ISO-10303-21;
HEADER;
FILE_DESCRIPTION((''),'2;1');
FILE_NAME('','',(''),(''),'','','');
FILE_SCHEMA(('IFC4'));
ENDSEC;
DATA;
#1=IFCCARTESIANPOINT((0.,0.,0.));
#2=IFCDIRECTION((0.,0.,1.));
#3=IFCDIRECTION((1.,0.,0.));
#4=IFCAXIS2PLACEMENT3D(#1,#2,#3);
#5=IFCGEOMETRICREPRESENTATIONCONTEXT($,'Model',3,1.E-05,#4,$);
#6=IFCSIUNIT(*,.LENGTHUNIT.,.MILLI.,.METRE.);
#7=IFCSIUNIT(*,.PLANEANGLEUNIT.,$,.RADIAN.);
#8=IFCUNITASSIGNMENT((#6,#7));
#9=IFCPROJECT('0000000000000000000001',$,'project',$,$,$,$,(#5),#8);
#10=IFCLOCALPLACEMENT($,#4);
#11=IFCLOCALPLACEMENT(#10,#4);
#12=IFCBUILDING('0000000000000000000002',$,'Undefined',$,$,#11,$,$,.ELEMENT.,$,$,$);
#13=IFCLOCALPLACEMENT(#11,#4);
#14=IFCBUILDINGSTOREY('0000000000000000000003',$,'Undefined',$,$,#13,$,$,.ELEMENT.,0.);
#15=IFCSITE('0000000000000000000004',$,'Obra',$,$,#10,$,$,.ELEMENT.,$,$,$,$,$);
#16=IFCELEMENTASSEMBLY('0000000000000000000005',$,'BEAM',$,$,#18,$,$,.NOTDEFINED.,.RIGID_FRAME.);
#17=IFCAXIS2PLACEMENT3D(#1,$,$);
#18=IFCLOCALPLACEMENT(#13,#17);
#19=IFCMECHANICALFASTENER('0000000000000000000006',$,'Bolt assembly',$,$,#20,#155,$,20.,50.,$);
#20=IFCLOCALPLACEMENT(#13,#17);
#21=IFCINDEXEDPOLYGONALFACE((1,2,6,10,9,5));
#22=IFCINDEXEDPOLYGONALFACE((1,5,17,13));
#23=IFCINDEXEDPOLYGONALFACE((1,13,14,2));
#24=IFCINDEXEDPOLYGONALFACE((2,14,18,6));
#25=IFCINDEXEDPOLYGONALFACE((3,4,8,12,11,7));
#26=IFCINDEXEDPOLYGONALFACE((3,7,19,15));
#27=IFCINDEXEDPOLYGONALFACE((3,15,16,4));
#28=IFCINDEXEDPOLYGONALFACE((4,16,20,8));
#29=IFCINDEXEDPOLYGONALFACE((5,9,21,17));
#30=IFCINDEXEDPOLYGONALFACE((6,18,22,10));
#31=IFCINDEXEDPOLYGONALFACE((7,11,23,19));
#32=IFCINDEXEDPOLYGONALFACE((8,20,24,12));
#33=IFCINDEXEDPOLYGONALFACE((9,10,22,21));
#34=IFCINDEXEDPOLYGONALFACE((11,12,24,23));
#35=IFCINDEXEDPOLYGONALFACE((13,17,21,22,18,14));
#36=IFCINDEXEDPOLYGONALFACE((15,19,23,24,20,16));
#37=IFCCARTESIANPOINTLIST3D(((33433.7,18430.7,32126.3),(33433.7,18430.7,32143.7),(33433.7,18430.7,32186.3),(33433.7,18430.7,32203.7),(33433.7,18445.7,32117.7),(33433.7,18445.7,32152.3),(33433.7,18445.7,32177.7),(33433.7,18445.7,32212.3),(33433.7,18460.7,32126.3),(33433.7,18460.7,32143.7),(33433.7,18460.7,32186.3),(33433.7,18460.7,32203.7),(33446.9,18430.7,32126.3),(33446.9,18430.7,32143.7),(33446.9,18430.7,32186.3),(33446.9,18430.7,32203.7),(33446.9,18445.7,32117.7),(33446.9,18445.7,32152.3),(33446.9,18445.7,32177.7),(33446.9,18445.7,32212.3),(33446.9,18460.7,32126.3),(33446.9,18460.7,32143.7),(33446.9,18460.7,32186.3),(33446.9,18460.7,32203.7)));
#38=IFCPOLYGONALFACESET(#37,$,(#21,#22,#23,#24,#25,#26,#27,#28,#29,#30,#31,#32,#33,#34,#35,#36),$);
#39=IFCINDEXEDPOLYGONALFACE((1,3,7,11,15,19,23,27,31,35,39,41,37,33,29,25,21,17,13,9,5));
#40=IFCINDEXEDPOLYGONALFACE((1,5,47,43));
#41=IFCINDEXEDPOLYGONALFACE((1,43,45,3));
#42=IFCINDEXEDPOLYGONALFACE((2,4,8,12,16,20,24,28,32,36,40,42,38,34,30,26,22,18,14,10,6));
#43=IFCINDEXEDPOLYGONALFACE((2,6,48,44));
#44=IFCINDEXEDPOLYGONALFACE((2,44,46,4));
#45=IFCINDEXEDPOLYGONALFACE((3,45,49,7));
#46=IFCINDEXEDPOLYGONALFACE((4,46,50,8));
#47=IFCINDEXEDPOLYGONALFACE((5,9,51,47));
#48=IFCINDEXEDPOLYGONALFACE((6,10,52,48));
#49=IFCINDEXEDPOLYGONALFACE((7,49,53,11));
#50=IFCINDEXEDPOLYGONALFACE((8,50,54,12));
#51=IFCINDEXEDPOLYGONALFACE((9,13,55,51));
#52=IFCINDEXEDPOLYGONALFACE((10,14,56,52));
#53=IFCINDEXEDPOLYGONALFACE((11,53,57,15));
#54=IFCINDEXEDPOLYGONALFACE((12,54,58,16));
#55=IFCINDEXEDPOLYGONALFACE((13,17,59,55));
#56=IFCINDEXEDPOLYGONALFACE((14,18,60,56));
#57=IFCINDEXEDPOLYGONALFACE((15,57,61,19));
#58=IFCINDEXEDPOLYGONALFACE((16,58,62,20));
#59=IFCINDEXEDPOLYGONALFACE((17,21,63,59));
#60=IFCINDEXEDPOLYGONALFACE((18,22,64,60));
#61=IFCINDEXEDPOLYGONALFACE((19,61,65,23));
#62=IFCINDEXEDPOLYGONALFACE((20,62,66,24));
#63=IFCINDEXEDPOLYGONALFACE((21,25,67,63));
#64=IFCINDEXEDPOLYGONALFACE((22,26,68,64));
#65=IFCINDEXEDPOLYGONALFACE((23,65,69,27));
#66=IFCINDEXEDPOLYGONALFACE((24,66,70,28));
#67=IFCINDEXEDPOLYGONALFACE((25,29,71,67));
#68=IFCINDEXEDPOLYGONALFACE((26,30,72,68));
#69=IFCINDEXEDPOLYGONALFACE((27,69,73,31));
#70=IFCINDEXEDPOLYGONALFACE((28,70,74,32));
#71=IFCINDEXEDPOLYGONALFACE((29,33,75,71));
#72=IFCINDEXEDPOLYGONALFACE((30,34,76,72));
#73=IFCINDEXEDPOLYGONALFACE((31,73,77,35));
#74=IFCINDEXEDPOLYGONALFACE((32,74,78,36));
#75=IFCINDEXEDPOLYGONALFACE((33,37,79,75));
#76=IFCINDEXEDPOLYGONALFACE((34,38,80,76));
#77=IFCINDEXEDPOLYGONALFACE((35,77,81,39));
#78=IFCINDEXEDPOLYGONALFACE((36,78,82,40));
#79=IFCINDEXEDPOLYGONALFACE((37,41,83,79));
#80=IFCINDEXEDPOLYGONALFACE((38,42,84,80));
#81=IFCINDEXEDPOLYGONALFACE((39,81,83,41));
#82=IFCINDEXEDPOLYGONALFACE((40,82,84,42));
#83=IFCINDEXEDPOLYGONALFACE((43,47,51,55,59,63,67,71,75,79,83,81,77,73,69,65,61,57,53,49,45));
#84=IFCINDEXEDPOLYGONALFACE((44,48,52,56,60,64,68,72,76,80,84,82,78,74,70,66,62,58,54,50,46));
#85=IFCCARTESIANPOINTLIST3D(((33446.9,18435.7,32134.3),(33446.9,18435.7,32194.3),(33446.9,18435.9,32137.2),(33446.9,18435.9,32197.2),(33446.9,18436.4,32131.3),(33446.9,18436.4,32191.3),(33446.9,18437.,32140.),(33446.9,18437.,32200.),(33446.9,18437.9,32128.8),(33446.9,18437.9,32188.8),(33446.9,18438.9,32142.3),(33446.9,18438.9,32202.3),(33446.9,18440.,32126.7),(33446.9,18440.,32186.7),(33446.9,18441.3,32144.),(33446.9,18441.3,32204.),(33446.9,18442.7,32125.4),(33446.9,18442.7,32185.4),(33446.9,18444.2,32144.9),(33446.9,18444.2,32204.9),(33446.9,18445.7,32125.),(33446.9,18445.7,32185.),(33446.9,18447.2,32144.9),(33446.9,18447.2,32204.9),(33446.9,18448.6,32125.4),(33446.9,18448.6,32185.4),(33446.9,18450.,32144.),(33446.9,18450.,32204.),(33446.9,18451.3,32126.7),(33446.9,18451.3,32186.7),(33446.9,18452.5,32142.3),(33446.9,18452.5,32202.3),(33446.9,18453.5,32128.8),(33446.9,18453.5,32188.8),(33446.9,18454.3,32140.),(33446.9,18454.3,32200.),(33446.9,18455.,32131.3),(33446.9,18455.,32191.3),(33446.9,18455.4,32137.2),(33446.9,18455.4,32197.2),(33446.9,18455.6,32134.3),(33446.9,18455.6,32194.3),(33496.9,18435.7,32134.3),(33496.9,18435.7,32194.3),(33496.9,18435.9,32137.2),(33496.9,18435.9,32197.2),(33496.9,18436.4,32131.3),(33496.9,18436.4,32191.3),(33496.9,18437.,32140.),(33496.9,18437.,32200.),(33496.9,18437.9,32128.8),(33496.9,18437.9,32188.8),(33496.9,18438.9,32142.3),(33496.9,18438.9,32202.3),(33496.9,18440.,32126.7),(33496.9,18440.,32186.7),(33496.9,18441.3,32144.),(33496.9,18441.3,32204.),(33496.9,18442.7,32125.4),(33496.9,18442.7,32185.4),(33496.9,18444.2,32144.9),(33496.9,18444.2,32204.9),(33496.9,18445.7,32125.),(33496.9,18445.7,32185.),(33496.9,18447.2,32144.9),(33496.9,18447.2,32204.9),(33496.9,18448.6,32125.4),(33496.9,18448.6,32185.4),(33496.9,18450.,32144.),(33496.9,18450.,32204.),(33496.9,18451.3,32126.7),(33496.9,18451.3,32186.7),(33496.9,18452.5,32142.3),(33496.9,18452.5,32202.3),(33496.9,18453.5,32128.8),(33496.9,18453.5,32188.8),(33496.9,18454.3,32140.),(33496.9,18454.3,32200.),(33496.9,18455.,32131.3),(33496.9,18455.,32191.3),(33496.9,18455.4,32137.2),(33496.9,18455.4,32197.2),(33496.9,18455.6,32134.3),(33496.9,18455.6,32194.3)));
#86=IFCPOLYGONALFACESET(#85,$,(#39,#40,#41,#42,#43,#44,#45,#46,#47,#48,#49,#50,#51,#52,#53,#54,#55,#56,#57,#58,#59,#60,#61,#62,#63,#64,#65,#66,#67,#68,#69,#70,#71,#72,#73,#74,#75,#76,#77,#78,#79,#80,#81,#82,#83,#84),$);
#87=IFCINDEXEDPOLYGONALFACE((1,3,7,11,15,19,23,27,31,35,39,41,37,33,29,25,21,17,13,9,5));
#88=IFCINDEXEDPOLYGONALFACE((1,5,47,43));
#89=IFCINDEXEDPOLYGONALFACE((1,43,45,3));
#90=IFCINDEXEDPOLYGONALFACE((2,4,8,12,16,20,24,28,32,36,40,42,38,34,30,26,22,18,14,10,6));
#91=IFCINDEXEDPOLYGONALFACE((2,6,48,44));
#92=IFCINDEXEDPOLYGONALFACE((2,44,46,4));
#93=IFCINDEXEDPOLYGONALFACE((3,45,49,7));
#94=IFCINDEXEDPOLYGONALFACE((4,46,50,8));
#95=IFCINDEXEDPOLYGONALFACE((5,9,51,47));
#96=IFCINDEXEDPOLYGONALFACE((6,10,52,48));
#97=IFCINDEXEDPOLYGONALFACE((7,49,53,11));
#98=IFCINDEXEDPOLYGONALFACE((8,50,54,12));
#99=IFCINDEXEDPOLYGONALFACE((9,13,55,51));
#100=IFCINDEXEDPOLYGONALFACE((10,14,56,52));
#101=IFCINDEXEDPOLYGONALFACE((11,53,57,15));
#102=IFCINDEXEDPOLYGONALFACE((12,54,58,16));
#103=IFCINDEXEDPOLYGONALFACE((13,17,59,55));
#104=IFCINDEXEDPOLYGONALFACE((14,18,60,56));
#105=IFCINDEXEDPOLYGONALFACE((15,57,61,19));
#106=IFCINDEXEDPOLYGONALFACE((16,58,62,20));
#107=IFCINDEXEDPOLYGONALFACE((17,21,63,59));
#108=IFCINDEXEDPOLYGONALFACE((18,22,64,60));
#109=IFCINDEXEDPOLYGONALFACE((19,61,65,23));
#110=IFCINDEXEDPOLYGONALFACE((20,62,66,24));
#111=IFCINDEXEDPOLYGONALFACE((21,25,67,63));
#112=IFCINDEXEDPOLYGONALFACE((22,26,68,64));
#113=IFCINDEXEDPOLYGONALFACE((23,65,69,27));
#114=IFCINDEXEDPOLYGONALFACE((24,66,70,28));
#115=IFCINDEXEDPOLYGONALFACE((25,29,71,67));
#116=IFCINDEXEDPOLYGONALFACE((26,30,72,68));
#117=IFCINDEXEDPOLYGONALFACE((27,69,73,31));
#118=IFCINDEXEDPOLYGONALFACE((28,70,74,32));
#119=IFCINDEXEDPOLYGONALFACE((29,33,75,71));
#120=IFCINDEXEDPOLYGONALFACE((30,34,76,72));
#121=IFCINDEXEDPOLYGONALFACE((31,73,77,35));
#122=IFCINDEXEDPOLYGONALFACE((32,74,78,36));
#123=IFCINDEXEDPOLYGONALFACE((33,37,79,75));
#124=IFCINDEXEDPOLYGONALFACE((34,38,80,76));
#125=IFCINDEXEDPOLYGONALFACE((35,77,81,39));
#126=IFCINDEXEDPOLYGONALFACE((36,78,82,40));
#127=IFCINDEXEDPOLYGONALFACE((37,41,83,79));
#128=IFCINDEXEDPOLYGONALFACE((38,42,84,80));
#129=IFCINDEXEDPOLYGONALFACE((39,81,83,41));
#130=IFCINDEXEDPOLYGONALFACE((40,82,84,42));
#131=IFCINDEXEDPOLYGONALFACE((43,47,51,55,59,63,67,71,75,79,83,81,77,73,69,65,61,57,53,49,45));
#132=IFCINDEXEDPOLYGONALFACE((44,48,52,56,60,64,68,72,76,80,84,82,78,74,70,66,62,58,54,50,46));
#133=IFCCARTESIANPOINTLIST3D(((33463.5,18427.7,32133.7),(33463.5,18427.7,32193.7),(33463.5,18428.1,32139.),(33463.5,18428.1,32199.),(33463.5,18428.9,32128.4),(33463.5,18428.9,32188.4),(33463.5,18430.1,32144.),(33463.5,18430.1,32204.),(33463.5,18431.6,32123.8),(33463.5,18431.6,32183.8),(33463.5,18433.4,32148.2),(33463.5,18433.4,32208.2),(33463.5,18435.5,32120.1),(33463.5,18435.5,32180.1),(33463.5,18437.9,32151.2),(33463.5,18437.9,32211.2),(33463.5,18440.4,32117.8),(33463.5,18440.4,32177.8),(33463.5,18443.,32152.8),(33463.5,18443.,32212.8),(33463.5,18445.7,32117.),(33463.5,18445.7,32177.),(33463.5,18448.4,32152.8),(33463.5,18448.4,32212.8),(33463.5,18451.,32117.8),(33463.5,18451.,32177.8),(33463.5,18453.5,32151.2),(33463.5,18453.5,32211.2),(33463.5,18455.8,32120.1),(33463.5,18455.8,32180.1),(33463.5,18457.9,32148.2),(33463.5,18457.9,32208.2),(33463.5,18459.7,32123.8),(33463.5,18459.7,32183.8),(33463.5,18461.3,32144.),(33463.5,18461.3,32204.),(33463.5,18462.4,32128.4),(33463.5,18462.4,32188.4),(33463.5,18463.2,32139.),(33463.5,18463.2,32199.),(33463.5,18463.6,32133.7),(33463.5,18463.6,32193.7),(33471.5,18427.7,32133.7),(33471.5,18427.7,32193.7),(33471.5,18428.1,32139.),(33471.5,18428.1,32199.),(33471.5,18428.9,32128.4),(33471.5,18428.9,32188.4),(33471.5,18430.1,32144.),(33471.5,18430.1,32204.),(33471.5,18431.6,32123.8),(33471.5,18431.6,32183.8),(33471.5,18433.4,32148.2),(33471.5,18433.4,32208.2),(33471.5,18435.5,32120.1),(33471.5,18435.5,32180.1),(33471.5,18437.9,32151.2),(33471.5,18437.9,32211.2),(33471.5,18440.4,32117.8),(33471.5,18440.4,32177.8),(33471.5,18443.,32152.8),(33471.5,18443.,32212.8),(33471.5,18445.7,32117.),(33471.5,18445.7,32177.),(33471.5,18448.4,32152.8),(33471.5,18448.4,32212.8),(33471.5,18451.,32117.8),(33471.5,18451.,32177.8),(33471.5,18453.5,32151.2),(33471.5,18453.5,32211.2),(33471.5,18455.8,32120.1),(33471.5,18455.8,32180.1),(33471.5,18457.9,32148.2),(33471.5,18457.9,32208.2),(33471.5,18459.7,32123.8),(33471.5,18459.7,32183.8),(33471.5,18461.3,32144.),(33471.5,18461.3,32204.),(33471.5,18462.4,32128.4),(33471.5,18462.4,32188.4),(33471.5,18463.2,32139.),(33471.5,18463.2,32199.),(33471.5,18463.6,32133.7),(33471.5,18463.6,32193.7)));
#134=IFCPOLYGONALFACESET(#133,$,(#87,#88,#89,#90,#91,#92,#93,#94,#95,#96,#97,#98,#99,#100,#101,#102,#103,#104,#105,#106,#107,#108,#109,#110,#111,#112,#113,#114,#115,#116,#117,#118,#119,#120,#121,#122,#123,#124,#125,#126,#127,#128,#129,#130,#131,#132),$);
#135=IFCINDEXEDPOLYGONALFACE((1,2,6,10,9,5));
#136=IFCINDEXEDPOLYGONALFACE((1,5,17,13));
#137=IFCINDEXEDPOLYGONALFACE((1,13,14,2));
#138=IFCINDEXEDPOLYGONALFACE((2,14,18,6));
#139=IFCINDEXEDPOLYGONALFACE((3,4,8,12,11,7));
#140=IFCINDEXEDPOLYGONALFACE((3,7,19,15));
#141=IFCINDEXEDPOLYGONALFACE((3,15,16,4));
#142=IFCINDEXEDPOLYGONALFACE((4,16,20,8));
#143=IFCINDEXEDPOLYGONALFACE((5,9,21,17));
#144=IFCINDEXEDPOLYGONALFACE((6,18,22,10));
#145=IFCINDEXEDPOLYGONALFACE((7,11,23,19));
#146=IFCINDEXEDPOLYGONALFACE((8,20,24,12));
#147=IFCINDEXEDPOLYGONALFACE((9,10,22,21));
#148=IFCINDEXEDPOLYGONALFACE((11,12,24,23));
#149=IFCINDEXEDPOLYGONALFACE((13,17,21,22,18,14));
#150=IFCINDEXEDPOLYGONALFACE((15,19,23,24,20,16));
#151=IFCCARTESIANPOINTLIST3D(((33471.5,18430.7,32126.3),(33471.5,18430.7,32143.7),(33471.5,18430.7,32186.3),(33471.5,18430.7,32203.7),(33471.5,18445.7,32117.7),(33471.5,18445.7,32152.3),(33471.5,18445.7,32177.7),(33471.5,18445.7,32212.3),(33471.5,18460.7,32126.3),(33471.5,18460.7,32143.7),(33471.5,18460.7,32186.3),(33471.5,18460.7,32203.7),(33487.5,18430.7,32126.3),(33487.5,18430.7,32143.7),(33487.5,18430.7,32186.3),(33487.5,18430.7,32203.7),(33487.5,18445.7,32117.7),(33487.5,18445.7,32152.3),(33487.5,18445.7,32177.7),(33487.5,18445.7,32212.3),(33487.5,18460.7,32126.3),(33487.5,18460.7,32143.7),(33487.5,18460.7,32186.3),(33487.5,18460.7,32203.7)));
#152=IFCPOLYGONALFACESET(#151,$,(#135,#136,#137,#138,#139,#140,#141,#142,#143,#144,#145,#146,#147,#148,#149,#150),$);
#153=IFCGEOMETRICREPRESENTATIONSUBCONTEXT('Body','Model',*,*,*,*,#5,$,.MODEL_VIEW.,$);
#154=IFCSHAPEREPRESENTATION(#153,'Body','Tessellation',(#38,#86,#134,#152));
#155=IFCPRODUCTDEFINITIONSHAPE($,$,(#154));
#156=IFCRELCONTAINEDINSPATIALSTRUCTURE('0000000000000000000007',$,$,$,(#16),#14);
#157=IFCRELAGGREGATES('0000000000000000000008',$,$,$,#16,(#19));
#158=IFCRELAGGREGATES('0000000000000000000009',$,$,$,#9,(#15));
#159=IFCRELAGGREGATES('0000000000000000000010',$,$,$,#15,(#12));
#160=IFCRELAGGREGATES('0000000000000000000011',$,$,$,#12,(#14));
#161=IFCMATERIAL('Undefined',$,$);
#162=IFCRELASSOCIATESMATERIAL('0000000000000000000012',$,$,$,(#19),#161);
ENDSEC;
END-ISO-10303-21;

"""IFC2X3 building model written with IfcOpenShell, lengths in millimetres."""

from ifc_helpers import new_model, si_unit, frame, origin_with_axes, origin_2d_with_axis, place, context, subcontext, project, spatial, polyline, circle, outline, extrude, source, transform, mapped, material, element, aggregate, save


model = new_model("IFC2X3")

# Units and contexts
model_context = context("Model", 3, precision=1e-05, world=origin_with_axes())
body_context = subcontext(model_context, "Body", "Model", "MODEL_VIEW")
ifc_project = project(units=[si_unit("LENGTHUNIT", "METRE", prefix="MILLI"), si_unit("PLANEANGLEUNIT", "RADIAN")], contexts=[model_context])

# Site, building, storey
site_placement = place(None, origin_with_axes())
site = spatial("IfcSite", under=ifc_project, at=site_placement, Name="Obra", CompositionType="ELEMENT")
building_placement = place(site_placement, origin_with_axes())
building = spatial("IfcBuilding", under=site, at=building_placement, Name="Undefined", CompositionType="ELEMENT")
storey_placement = place(building_placement, origin_with_axes())
storey = spatial("IfcBuildingStorey", under=building, at=storey_placement, Name="Undefined", CompositionType="ELEMENT", Elevation=0.0)

# Element assembly
assembly_1_placement = place(storey_placement, origin_with_axes())
assembly_1 = element("IfcElementAssembly", 1, at=assembly_1_placement, inside=storey, Name="BEAM", AssemblyPlace="NOTDEFINED", PredefinedType="RIGID_FRAME")

# Mechanical fastener
ifc_material_1 = material(Name="Undefined")
shared_shape_1 = source(origin_with_axes(), body_context, "Body", "SweptSolid", [
    extrude(outline(polyline([(17.3, 0.0), (8.7, 15.0), (-8.7, 15.0), (-17.3, 0.0), (-8.7, -15.0), (8.7, -15.0), (17.3, 0.0)])), frame((0.0, -26.5, 0.0), z_axis=(0.0, 1.0, 0.0), x_axis=(1.0, 0.0, 0.0)), (0.0, 0.0, 1.0), 13.2),
    extrude(circle(Radius=10.0, at=origin_2d_with_axis()), frame((0.0, -13.3, 0.0), z_axis=(0.0, 1.0, 0.0), x_axis=(1.0, 0.0, 0.0)), (0.0, 0.0, 1.0), 50.0),
    extrude(circle(Radius=18.0, at=origin_2d_with_axis()), frame((0.0, 3.3, 0.0), z_axis=(0.0, 1.0, 0.0), x_axis=(1.0, 0.0, 0.0)), (0.0, 0.0, 1.0), 8.0),
    extrude(outline(polyline([(17.3, 0.0), (8.7, 15.0), (-8.7, 15.0), (-17.3, 0.0), (-8.7, -15.0), (8.7, -15.0), (17.3, 0.0)])), frame((0.0, 11.3, 0.0), z_axis=(0.0, 1.0, 0.0), x_axis=(1.0, 0.0, 0.0)), (0.0, 0.0, 1.0), 16.0),
])
mechanical_fastener_1_placement = place(assembly_1_placement, frame((33460.2, 18485.7, 32235.0), z_axis=(0.0, -1.0, 0.0), x_axis=(0.0, 0.0, -1.0)))
mechanical_fastener_1 = element("IfcMechanicalFastener", 2, at=mechanical_fastener_1_placement, material=ifc_material_1, Name="Bolt assembly", NominalDiameter=20.0, NominalLength=50.0, context=body_context, shape_type="MappedRepresentation", body=[
    mapped(shared_shape_1, transform((40.0, 0.0, 40.0))),
    mapped(shared_shape_1, transform((100.0, 0.0, 40.0))),
])
aggregate(assembly_1, [mechanical_fastener_1])

save(model, "model.ifc")
